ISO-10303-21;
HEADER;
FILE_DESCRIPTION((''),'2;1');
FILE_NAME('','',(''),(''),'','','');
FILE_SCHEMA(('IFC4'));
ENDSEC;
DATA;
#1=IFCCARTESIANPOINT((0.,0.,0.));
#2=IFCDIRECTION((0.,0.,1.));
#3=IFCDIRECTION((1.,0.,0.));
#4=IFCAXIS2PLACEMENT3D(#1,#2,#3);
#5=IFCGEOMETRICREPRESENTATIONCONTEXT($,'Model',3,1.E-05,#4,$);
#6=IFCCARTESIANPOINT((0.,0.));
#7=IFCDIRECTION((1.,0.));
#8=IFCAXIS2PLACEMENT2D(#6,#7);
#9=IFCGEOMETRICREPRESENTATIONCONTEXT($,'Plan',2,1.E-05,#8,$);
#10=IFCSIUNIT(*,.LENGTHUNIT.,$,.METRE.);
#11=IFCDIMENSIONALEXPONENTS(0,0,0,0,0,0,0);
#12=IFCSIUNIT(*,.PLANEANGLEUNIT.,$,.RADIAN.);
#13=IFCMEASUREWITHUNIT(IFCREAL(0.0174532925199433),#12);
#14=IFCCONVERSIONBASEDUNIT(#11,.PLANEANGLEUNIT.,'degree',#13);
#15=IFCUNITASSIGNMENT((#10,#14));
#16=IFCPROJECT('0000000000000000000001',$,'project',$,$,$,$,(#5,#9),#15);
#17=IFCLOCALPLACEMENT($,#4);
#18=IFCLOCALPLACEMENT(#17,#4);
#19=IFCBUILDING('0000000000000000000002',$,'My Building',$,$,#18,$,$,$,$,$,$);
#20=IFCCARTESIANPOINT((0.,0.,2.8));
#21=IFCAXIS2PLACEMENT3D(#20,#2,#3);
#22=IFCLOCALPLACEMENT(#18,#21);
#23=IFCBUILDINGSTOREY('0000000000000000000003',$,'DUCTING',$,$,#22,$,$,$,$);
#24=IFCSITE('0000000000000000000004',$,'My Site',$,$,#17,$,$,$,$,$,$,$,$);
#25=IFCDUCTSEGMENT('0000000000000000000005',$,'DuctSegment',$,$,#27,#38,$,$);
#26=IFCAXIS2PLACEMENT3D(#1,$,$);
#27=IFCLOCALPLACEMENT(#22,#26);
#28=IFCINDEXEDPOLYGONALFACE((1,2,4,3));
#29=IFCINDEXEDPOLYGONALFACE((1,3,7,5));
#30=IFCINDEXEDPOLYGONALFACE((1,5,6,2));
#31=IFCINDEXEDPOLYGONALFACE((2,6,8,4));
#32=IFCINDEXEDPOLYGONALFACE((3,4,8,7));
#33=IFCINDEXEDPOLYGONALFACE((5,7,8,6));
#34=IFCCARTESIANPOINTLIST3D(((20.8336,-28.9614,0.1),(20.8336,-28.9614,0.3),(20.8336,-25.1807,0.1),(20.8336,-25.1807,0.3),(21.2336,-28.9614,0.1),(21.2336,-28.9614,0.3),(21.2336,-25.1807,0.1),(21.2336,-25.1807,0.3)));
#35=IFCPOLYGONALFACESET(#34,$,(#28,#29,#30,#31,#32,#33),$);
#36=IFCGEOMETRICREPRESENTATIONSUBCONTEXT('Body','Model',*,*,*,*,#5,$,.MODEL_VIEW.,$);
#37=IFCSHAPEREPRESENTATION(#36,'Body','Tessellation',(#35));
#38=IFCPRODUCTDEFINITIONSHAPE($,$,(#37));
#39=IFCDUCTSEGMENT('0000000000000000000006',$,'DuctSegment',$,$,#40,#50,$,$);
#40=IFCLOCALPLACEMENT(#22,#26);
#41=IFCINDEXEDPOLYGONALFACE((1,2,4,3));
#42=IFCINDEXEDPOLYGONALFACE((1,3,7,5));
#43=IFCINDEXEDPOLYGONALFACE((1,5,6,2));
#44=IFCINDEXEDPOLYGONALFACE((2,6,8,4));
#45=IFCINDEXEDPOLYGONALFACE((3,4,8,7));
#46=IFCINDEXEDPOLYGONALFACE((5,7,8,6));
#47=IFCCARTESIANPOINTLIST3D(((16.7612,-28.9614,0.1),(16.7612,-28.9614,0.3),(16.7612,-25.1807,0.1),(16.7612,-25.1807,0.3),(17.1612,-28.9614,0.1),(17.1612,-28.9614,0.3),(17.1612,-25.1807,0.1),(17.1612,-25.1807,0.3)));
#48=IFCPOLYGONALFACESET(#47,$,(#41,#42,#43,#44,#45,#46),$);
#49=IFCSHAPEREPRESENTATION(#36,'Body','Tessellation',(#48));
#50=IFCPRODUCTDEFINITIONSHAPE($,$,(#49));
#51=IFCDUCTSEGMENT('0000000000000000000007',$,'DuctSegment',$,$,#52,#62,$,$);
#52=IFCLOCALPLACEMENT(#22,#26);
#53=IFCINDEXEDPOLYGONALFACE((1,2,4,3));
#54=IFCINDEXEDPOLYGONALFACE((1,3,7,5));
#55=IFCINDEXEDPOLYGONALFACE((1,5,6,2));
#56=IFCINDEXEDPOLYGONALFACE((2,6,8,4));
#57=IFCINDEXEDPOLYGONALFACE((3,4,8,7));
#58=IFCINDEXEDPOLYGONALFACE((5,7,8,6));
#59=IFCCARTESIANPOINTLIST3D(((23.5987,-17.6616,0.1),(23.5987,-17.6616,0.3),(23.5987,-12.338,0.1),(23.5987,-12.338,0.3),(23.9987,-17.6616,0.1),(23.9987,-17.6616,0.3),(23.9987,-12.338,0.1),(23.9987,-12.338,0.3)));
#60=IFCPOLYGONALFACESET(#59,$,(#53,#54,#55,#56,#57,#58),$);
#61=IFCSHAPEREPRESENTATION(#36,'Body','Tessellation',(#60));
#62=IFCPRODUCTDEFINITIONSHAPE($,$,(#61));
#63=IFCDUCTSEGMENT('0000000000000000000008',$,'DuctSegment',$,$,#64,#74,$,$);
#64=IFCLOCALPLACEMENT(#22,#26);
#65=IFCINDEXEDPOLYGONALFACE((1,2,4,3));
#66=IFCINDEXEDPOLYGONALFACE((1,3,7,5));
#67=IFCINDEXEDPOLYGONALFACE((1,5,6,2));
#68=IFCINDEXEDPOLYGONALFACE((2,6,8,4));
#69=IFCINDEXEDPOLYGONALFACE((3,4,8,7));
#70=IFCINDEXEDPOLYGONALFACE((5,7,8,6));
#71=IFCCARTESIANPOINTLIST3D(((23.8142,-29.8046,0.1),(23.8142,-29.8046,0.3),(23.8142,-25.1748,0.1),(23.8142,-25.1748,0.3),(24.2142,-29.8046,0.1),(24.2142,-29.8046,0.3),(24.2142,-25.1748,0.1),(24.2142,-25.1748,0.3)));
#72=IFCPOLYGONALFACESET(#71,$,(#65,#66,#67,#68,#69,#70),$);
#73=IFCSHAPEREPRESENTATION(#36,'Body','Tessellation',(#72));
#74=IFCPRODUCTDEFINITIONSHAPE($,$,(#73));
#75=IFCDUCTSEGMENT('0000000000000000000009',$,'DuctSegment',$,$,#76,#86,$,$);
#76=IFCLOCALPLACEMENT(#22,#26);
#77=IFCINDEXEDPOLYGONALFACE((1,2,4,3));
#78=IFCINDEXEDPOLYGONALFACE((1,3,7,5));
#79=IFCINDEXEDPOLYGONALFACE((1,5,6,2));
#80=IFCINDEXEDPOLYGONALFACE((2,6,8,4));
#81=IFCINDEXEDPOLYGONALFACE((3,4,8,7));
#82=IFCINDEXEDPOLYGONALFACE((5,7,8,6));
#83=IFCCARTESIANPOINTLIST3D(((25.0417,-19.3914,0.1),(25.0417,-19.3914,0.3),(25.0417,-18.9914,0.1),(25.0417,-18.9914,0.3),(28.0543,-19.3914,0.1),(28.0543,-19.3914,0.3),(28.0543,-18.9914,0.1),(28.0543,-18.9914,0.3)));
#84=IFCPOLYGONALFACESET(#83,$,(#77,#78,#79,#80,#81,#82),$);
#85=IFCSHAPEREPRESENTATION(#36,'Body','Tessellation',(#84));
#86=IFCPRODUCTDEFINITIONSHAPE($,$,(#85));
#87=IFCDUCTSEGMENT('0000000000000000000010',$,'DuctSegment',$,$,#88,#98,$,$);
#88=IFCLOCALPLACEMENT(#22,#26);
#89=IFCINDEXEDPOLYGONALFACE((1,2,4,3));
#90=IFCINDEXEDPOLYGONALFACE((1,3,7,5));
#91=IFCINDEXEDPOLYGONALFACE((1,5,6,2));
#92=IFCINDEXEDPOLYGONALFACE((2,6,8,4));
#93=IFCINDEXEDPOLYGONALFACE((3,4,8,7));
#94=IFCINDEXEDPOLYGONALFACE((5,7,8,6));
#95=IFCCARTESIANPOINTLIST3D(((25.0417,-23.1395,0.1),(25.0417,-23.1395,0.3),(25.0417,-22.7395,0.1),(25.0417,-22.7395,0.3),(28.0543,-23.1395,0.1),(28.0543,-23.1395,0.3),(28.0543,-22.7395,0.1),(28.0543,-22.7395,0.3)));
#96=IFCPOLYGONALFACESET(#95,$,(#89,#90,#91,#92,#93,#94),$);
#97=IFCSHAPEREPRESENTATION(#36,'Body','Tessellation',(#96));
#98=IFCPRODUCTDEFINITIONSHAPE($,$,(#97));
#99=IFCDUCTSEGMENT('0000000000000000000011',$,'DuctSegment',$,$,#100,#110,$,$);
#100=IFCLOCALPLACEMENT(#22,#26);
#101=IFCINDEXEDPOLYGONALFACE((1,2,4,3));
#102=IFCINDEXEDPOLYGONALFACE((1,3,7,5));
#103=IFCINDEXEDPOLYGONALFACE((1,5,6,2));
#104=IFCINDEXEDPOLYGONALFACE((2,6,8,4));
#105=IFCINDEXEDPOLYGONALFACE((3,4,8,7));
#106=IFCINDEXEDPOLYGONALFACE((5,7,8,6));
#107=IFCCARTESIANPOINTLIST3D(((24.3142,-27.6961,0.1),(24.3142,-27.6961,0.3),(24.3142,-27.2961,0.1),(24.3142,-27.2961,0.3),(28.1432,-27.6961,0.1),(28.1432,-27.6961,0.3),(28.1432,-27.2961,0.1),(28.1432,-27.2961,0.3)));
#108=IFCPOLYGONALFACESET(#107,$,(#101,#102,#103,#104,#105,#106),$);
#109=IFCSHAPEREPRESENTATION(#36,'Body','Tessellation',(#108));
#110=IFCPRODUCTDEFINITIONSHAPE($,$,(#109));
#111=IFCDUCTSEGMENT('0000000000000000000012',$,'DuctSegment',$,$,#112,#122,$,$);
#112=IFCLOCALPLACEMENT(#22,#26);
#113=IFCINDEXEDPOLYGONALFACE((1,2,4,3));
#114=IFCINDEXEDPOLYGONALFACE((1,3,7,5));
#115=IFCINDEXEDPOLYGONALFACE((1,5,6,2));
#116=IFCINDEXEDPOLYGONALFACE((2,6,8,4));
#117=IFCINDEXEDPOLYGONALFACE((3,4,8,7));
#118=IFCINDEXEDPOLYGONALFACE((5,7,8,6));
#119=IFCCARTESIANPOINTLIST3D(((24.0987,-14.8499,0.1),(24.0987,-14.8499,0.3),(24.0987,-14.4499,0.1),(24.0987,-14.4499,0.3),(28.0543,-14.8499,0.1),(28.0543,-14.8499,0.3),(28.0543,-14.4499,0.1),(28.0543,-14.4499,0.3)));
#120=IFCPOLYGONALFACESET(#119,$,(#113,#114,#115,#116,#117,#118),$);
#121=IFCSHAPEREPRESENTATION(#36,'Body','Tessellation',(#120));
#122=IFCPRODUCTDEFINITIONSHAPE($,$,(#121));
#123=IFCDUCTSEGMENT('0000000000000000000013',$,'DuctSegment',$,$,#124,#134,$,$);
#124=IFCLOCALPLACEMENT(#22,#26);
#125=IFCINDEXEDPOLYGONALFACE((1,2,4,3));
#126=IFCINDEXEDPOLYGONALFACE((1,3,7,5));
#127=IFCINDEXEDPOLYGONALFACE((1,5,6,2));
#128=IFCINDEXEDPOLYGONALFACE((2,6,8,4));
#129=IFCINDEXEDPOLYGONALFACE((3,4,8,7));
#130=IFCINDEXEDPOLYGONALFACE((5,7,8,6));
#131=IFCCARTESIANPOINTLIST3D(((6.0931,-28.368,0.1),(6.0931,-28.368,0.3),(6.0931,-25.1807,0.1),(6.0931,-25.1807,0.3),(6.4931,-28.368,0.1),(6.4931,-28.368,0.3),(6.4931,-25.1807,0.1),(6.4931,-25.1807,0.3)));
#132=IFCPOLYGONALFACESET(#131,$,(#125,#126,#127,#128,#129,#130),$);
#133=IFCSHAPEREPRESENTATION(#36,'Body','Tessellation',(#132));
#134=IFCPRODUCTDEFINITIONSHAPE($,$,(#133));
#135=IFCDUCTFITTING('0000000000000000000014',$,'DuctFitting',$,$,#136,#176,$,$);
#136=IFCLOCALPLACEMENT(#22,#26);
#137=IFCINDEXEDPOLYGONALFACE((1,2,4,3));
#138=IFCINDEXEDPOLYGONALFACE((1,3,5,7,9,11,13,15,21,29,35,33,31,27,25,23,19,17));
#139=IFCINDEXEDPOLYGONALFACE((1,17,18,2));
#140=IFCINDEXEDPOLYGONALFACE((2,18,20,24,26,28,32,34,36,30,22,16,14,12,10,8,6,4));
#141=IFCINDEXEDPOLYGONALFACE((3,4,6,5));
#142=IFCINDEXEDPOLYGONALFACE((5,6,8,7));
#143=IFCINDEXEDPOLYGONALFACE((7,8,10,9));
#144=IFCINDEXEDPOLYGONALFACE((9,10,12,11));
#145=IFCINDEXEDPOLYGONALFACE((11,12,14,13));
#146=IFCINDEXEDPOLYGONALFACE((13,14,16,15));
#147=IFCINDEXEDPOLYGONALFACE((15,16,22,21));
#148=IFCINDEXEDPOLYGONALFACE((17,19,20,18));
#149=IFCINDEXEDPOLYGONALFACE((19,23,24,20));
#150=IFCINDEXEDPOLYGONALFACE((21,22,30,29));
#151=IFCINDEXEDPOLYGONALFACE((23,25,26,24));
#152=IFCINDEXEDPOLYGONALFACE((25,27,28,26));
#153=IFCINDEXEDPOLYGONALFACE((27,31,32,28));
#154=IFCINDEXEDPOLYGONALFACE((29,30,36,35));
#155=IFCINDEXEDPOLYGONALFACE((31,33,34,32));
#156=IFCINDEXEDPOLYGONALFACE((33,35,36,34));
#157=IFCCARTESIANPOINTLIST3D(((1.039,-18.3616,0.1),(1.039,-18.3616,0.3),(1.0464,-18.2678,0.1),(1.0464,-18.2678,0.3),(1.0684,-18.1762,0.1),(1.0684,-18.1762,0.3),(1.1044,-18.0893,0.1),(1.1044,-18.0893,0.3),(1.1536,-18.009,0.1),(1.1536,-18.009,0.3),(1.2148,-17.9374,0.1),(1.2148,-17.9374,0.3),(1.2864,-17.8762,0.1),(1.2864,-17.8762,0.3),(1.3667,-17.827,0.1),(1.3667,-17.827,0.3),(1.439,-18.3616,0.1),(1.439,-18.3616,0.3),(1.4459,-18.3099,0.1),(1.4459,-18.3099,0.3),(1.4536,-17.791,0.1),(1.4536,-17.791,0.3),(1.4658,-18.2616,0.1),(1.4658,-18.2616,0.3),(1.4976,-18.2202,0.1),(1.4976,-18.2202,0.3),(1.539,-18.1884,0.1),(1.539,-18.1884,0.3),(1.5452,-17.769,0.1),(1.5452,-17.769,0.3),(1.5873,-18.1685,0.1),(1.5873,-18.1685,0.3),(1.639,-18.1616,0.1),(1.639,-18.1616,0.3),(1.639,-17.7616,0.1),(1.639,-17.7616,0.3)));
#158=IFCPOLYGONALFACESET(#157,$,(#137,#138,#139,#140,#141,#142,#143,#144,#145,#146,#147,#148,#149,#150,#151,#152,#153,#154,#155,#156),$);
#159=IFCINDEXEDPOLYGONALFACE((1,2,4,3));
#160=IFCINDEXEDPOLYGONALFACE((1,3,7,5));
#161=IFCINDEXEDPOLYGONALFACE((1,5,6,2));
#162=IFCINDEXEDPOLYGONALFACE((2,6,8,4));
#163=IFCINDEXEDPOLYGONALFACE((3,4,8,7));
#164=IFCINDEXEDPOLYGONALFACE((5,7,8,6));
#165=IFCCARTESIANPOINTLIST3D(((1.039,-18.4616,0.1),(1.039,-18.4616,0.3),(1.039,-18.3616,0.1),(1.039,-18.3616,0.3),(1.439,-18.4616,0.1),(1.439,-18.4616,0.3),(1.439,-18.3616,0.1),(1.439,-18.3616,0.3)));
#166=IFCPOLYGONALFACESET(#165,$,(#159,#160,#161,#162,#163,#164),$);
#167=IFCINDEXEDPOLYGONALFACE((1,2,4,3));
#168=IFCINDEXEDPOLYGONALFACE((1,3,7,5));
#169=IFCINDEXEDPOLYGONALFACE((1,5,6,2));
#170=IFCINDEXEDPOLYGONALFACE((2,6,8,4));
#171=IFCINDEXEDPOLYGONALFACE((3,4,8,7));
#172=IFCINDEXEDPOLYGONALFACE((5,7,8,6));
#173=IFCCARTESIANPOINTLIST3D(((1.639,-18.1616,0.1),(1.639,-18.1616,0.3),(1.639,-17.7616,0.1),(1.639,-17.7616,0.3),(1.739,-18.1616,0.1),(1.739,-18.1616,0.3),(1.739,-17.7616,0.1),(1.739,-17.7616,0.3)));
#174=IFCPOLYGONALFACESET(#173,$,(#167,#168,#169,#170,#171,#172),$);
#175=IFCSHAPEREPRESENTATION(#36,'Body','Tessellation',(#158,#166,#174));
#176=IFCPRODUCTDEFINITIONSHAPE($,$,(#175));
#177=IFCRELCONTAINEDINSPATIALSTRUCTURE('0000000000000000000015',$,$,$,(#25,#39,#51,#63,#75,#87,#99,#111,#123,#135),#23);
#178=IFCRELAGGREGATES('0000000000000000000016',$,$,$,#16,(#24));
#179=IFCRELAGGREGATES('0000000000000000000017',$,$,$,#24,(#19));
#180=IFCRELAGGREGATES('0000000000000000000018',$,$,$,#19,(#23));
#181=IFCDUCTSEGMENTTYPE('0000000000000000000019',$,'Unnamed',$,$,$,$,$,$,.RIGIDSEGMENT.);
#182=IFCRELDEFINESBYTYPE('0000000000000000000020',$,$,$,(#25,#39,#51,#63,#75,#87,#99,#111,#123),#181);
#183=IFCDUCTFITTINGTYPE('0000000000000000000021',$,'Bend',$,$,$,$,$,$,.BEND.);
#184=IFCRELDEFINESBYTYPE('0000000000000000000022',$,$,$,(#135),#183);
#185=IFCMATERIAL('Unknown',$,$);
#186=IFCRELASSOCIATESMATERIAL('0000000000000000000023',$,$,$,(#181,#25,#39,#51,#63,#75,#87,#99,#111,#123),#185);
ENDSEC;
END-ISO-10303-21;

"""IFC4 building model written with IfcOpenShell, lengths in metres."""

from ifc_helpers import new_model, entity, si_unit, converted_unit, frame, origin_with_axes, origin_2d_with_axis, place, context, subcontext, project, spatial, line, arc, indexed_curve, rectangle, outline, extrude, source, transform, mapped, material, material_profile, profile_set, profile_usage, type_object, type_shapes, element, save


model = new_model("IFC4")

# Units and contexts
model_context = context("Model", 3, precision=1e-05, world=origin_with_axes())
plan_context = context("Plan", 2, precision=1e-05, world=origin_2d_with_axis())
body_context = subcontext(model_context, "Body", "Model", "MODEL_VIEW")
ifc_project = project(units=[si_unit("LENGTHUNIT", "METRE"), converted_unit("PLANEANGLEUNIT", "degree", entity("IfcReal", 0.0174532925199433), si_unit("PLANEANGLEUNIT", "RADIAN"), dimensions=[0, 0, 0, 0, 0, 0, 0])], contexts=[model_context, plan_context])

# Site, building, storey
site_placement = place(None, origin_with_axes())
site = spatial("IfcSite", under=ifc_project, at=site_placement, Name="My Site")
building_placement = place(site_placement, origin_with_axes())
building = spatial("IfcBuilding", under=site, at=building_placement, Name="My Building")
storey_placement = place(building_placement, frame((0.0, 0.0, 2.8), z_axis=(0.0, 0.0, 1.0), x_axis=(1.0, 0.0, 0.0)))
storey = spatial("IfcBuildingStorey", under=building, at=storey_placement, Name="DUCTING")

# Duct segments
ifc_material = material(Name="Unknown")
ifc_material_profile = material_profile(ifc_material, rectangle(XDim=0.4, YDim=0.2))
ifc_profile_set = profile_set([ifc_material_profile])
duct_segment_type = type_object("IfcDuctSegmentType", Name="Unnamed", PredefinedType="RIGIDSEGMENT", material=ifc_profile_set)
ifc_profile_usage_1 = profile_usage(ifc_profile_set, cardinal=5)
duct_segment_1_placement = place(storey_placement, frame((21.0336, -25.1807, 0.2), z_axis=(0.0, -1.0, 0.0), x_axis=(1.0, 0.0, 0.0)))
element("IfcDuctSegment", 1, at=duct_segment_1_placement, inside=storey, type_object=duct_segment_type, material=ifc_profile_usage_1, Name="DuctSegment", context=body_context, shape_type="SweptSolid", body=[
    extrude(rectangle(XDim=0.4, YDim=0.2), origin_with_axes(), (0.0, 0.0, 1.0), 3.7807),
])
ifc_profile_usage_2 = profile_usage(ifc_profile_set, cardinal=5)
duct_segment_2_placement = place(storey_placement, frame((16.9612, -25.1807, 0.2), z_axis=(0.0, -1.0, 0.0), x_axis=(1.0, 0.0, 0.0)))
element("IfcDuctSegment", 2, at=duct_segment_2_placement, inside=storey, type_object=duct_segment_type, material=ifc_profile_usage_2, Name="DuctSegment", context=body_context, shape_type="SweptSolid", body=[
    extrude(rectangle(XDim=0.4, YDim=0.2), origin_with_axes(), (0.0, 0.0, 1.0), 3.7807),
])
ifc_profile_usage_3 = profile_usage(ifc_profile_set, cardinal=5)
duct_segment_3_placement = place(storey_placement, frame((23.7987, -17.6616, 0.2), z_axis=(0.0, 1.0, 0.0), x_axis=(-1.0, 0.0, 0.0)))
element("IfcDuctSegment", 3, at=duct_segment_3_placement, inside=storey, type_object=duct_segment_type, material=ifc_profile_usage_3, Name="DuctSegment", context=body_context, shape_type="SweptSolid", body=[
    extrude(rectangle(XDim=0.4, YDim=0.2), origin_with_axes(), (0.0, 0.0, 1.0), 5.3237),
])
ifc_profile_usage_4 = profile_usage(ifc_profile_set, cardinal=5)
duct_segment_4_placement = place(storey_placement, frame((24.0142, -25.1748, 0.2), z_axis=(0.0, -1.0, 0.0), x_axis=(1.0, 0.0, 0.0)))
element("IfcDuctSegment", 4, at=duct_segment_4_placement, inside=storey, type_object=duct_segment_type, material=ifc_profile_usage_4, Name="DuctSegment", context=body_context, shape_type="SweptSolid", body=[
    extrude(rectangle(XDim=0.4, YDim=0.2), origin_with_axes(), (0.0, 0.0, 1.0), 4.6298),
])
ifc_profile_usage_5 = profile_usage(ifc_profile_set, cardinal=5)
duct_segment_5_placement = place(storey_placement, frame((25.0417, -19.1914, 0.2), z_axis=(1.0, 0.0, 0.0), x_axis=(0.0, 1.0, 0.0)))
element("IfcDuctSegment", 5, at=duct_segment_5_placement, inside=storey, type_object=duct_segment_type, material=ifc_profile_usage_5, Name="DuctSegment", context=body_context, shape_type="SweptSolid", body=[
    extrude(rectangle(XDim=0.4, YDim=0.2), origin_with_axes(), (0.0, 0.0, 1.0), 3.0126),
])
ifc_profile_usage_6 = profile_usage(ifc_profile_set, cardinal=5)
duct_segment_6_placement = place(storey_placement, frame((25.0417, -22.9395, 0.2), z_axis=(1.0, 0.0, 0.0), x_axis=(0.0, 1.0, 0.0)))
element("IfcDuctSegment", 6, at=duct_segment_6_placement, inside=storey, type_object=duct_segment_type, material=ifc_profile_usage_6, Name="DuctSegment", context=body_context, shape_type="SweptSolid", body=[
    extrude(rectangle(XDim=0.4, YDim=0.2), origin_with_axes(), (0.0, 0.0, 1.0), 3.0126),
])
ifc_profile_usage_7 = profile_usage(ifc_profile_set, cardinal=5)
duct_segment_7_placement = place(storey_placement, frame((24.3142, -27.4961, 0.2), z_axis=(1.0, 0.0, 0.0), x_axis=(0.0, 1.0, 0.0)))
element("IfcDuctSegment", 7, at=duct_segment_7_placement, inside=storey, type_object=duct_segment_type, material=ifc_profile_usage_7, Name="DuctSegment", context=body_context, shape_type="SweptSolid", body=[
    extrude(rectangle(XDim=0.4, YDim=0.2), origin_with_axes(), (0.0, 0.0, 1.0), 3.8289),
])
ifc_profile_usage_8 = profile_usage(ifc_profile_set, cardinal=5)
duct_segment_8_placement = place(storey_placement, frame((24.0987, -14.6499, 0.2), z_axis=(1.0, 0.0, 0.0), x_axis=(0.0, 1.0, 0.0)))
element("IfcDuctSegment", 8, at=duct_segment_8_placement, inside=storey, type_object=duct_segment_type, material=ifc_profile_usage_8, Name="DuctSegment", context=body_context, shape_type="SweptSolid", body=[
    extrude(rectangle(XDim=0.4, YDim=0.2), origin_with_axes(), (0.0, 0.0, 1.0), 3.9556),
])
ifc_profile_usage_9 = profile_usage(ifc_profile_set, cardinal=5)
duct_segment_9_placement = place(storey_placement, frame((6.2931, -25.1807, 0.2), z_axis=(0.0, -1.0, 0.0), x_axis=(1.0, 0.0, 0.0)))
element("IfcDuctSegment", 9, at=duct_segment_9_placement, inside=storey, type_object=duct_segment_type, material=ifc_profile_usage_9, Name="DuctSegment", context=body_context, shape_type="SweptSolid", body=[
    extrude(rectangle(XDim=0.4, YDim=0.2), origin_with_axes(), (0.0, 0.0, 1.0), 3.1873),
])

# Duct fitting
duct_fitting_type = type_object("IfcDuctFittingType", Name="Bend", PredefinedType="BEND")
shared_shape = source(origin_with_axes(), body_context, "Body", "SweptSolid", [
    extrude(outline(indexed_curve([(0.2, 0.0), (0.2586, -0.1414), (0.4, -0.2), (0.4, -0.6), (-0.0243, -0.4243), (-0.2, 0.0)], segments=[arc(1, 2, 3), line(3, 4), arc(4, 5, 6), line(6, 1)])), frame((0.0, -0.1, -0.1), z_axis=(0.0, -1.0, 0.0), x_axis=(1.0, 0.0, 0.0)), (0.0, 0.0, -1.0), 0.2),
    extrude(rectangle(XDim=0.4, YDim=0.2), origin_with_axes(), (0.0, 0.0, -1.0), 0.1),
    extrude(rectangle(XDim=0.4, YDim=0.2), frame((0.4, 0.0, -0.5), z_axis=(1.0, 0.0, 0.0), x_axis=(0.0, 0.0, 1.0)), (0.0, 0.0, 1.0), 0.1),
])
type_shapes(duct_fitting_type, [shared_shape])
for number, where, z_axis, x_axis, name in (
    (10, (1.239, -18.4616, 0.2), (0.0, -1.0, 0.0), (1.0, 0.0, 0.0), "DuctFitting"),
):
    element("IfcDuctFitting", number, at=place(storey_placement, frame(where, z_axis=z_axis, x_axis=x_axis)), inside=storey, type_object=duct_fitting_type, Name=name, context=body_context, shape_type="MappedRepresentation", body=[
        mapped(shared_shape, transform((0.0, 0.0, 0.0), x_axis=(1.0, 0.0, 0.0), y_axis=(0.0, 1.0, 0.0), z_axis=(0.0, 0.0, 1.0), scale=1.0)),
    ])

save(model, "model.ifc")
